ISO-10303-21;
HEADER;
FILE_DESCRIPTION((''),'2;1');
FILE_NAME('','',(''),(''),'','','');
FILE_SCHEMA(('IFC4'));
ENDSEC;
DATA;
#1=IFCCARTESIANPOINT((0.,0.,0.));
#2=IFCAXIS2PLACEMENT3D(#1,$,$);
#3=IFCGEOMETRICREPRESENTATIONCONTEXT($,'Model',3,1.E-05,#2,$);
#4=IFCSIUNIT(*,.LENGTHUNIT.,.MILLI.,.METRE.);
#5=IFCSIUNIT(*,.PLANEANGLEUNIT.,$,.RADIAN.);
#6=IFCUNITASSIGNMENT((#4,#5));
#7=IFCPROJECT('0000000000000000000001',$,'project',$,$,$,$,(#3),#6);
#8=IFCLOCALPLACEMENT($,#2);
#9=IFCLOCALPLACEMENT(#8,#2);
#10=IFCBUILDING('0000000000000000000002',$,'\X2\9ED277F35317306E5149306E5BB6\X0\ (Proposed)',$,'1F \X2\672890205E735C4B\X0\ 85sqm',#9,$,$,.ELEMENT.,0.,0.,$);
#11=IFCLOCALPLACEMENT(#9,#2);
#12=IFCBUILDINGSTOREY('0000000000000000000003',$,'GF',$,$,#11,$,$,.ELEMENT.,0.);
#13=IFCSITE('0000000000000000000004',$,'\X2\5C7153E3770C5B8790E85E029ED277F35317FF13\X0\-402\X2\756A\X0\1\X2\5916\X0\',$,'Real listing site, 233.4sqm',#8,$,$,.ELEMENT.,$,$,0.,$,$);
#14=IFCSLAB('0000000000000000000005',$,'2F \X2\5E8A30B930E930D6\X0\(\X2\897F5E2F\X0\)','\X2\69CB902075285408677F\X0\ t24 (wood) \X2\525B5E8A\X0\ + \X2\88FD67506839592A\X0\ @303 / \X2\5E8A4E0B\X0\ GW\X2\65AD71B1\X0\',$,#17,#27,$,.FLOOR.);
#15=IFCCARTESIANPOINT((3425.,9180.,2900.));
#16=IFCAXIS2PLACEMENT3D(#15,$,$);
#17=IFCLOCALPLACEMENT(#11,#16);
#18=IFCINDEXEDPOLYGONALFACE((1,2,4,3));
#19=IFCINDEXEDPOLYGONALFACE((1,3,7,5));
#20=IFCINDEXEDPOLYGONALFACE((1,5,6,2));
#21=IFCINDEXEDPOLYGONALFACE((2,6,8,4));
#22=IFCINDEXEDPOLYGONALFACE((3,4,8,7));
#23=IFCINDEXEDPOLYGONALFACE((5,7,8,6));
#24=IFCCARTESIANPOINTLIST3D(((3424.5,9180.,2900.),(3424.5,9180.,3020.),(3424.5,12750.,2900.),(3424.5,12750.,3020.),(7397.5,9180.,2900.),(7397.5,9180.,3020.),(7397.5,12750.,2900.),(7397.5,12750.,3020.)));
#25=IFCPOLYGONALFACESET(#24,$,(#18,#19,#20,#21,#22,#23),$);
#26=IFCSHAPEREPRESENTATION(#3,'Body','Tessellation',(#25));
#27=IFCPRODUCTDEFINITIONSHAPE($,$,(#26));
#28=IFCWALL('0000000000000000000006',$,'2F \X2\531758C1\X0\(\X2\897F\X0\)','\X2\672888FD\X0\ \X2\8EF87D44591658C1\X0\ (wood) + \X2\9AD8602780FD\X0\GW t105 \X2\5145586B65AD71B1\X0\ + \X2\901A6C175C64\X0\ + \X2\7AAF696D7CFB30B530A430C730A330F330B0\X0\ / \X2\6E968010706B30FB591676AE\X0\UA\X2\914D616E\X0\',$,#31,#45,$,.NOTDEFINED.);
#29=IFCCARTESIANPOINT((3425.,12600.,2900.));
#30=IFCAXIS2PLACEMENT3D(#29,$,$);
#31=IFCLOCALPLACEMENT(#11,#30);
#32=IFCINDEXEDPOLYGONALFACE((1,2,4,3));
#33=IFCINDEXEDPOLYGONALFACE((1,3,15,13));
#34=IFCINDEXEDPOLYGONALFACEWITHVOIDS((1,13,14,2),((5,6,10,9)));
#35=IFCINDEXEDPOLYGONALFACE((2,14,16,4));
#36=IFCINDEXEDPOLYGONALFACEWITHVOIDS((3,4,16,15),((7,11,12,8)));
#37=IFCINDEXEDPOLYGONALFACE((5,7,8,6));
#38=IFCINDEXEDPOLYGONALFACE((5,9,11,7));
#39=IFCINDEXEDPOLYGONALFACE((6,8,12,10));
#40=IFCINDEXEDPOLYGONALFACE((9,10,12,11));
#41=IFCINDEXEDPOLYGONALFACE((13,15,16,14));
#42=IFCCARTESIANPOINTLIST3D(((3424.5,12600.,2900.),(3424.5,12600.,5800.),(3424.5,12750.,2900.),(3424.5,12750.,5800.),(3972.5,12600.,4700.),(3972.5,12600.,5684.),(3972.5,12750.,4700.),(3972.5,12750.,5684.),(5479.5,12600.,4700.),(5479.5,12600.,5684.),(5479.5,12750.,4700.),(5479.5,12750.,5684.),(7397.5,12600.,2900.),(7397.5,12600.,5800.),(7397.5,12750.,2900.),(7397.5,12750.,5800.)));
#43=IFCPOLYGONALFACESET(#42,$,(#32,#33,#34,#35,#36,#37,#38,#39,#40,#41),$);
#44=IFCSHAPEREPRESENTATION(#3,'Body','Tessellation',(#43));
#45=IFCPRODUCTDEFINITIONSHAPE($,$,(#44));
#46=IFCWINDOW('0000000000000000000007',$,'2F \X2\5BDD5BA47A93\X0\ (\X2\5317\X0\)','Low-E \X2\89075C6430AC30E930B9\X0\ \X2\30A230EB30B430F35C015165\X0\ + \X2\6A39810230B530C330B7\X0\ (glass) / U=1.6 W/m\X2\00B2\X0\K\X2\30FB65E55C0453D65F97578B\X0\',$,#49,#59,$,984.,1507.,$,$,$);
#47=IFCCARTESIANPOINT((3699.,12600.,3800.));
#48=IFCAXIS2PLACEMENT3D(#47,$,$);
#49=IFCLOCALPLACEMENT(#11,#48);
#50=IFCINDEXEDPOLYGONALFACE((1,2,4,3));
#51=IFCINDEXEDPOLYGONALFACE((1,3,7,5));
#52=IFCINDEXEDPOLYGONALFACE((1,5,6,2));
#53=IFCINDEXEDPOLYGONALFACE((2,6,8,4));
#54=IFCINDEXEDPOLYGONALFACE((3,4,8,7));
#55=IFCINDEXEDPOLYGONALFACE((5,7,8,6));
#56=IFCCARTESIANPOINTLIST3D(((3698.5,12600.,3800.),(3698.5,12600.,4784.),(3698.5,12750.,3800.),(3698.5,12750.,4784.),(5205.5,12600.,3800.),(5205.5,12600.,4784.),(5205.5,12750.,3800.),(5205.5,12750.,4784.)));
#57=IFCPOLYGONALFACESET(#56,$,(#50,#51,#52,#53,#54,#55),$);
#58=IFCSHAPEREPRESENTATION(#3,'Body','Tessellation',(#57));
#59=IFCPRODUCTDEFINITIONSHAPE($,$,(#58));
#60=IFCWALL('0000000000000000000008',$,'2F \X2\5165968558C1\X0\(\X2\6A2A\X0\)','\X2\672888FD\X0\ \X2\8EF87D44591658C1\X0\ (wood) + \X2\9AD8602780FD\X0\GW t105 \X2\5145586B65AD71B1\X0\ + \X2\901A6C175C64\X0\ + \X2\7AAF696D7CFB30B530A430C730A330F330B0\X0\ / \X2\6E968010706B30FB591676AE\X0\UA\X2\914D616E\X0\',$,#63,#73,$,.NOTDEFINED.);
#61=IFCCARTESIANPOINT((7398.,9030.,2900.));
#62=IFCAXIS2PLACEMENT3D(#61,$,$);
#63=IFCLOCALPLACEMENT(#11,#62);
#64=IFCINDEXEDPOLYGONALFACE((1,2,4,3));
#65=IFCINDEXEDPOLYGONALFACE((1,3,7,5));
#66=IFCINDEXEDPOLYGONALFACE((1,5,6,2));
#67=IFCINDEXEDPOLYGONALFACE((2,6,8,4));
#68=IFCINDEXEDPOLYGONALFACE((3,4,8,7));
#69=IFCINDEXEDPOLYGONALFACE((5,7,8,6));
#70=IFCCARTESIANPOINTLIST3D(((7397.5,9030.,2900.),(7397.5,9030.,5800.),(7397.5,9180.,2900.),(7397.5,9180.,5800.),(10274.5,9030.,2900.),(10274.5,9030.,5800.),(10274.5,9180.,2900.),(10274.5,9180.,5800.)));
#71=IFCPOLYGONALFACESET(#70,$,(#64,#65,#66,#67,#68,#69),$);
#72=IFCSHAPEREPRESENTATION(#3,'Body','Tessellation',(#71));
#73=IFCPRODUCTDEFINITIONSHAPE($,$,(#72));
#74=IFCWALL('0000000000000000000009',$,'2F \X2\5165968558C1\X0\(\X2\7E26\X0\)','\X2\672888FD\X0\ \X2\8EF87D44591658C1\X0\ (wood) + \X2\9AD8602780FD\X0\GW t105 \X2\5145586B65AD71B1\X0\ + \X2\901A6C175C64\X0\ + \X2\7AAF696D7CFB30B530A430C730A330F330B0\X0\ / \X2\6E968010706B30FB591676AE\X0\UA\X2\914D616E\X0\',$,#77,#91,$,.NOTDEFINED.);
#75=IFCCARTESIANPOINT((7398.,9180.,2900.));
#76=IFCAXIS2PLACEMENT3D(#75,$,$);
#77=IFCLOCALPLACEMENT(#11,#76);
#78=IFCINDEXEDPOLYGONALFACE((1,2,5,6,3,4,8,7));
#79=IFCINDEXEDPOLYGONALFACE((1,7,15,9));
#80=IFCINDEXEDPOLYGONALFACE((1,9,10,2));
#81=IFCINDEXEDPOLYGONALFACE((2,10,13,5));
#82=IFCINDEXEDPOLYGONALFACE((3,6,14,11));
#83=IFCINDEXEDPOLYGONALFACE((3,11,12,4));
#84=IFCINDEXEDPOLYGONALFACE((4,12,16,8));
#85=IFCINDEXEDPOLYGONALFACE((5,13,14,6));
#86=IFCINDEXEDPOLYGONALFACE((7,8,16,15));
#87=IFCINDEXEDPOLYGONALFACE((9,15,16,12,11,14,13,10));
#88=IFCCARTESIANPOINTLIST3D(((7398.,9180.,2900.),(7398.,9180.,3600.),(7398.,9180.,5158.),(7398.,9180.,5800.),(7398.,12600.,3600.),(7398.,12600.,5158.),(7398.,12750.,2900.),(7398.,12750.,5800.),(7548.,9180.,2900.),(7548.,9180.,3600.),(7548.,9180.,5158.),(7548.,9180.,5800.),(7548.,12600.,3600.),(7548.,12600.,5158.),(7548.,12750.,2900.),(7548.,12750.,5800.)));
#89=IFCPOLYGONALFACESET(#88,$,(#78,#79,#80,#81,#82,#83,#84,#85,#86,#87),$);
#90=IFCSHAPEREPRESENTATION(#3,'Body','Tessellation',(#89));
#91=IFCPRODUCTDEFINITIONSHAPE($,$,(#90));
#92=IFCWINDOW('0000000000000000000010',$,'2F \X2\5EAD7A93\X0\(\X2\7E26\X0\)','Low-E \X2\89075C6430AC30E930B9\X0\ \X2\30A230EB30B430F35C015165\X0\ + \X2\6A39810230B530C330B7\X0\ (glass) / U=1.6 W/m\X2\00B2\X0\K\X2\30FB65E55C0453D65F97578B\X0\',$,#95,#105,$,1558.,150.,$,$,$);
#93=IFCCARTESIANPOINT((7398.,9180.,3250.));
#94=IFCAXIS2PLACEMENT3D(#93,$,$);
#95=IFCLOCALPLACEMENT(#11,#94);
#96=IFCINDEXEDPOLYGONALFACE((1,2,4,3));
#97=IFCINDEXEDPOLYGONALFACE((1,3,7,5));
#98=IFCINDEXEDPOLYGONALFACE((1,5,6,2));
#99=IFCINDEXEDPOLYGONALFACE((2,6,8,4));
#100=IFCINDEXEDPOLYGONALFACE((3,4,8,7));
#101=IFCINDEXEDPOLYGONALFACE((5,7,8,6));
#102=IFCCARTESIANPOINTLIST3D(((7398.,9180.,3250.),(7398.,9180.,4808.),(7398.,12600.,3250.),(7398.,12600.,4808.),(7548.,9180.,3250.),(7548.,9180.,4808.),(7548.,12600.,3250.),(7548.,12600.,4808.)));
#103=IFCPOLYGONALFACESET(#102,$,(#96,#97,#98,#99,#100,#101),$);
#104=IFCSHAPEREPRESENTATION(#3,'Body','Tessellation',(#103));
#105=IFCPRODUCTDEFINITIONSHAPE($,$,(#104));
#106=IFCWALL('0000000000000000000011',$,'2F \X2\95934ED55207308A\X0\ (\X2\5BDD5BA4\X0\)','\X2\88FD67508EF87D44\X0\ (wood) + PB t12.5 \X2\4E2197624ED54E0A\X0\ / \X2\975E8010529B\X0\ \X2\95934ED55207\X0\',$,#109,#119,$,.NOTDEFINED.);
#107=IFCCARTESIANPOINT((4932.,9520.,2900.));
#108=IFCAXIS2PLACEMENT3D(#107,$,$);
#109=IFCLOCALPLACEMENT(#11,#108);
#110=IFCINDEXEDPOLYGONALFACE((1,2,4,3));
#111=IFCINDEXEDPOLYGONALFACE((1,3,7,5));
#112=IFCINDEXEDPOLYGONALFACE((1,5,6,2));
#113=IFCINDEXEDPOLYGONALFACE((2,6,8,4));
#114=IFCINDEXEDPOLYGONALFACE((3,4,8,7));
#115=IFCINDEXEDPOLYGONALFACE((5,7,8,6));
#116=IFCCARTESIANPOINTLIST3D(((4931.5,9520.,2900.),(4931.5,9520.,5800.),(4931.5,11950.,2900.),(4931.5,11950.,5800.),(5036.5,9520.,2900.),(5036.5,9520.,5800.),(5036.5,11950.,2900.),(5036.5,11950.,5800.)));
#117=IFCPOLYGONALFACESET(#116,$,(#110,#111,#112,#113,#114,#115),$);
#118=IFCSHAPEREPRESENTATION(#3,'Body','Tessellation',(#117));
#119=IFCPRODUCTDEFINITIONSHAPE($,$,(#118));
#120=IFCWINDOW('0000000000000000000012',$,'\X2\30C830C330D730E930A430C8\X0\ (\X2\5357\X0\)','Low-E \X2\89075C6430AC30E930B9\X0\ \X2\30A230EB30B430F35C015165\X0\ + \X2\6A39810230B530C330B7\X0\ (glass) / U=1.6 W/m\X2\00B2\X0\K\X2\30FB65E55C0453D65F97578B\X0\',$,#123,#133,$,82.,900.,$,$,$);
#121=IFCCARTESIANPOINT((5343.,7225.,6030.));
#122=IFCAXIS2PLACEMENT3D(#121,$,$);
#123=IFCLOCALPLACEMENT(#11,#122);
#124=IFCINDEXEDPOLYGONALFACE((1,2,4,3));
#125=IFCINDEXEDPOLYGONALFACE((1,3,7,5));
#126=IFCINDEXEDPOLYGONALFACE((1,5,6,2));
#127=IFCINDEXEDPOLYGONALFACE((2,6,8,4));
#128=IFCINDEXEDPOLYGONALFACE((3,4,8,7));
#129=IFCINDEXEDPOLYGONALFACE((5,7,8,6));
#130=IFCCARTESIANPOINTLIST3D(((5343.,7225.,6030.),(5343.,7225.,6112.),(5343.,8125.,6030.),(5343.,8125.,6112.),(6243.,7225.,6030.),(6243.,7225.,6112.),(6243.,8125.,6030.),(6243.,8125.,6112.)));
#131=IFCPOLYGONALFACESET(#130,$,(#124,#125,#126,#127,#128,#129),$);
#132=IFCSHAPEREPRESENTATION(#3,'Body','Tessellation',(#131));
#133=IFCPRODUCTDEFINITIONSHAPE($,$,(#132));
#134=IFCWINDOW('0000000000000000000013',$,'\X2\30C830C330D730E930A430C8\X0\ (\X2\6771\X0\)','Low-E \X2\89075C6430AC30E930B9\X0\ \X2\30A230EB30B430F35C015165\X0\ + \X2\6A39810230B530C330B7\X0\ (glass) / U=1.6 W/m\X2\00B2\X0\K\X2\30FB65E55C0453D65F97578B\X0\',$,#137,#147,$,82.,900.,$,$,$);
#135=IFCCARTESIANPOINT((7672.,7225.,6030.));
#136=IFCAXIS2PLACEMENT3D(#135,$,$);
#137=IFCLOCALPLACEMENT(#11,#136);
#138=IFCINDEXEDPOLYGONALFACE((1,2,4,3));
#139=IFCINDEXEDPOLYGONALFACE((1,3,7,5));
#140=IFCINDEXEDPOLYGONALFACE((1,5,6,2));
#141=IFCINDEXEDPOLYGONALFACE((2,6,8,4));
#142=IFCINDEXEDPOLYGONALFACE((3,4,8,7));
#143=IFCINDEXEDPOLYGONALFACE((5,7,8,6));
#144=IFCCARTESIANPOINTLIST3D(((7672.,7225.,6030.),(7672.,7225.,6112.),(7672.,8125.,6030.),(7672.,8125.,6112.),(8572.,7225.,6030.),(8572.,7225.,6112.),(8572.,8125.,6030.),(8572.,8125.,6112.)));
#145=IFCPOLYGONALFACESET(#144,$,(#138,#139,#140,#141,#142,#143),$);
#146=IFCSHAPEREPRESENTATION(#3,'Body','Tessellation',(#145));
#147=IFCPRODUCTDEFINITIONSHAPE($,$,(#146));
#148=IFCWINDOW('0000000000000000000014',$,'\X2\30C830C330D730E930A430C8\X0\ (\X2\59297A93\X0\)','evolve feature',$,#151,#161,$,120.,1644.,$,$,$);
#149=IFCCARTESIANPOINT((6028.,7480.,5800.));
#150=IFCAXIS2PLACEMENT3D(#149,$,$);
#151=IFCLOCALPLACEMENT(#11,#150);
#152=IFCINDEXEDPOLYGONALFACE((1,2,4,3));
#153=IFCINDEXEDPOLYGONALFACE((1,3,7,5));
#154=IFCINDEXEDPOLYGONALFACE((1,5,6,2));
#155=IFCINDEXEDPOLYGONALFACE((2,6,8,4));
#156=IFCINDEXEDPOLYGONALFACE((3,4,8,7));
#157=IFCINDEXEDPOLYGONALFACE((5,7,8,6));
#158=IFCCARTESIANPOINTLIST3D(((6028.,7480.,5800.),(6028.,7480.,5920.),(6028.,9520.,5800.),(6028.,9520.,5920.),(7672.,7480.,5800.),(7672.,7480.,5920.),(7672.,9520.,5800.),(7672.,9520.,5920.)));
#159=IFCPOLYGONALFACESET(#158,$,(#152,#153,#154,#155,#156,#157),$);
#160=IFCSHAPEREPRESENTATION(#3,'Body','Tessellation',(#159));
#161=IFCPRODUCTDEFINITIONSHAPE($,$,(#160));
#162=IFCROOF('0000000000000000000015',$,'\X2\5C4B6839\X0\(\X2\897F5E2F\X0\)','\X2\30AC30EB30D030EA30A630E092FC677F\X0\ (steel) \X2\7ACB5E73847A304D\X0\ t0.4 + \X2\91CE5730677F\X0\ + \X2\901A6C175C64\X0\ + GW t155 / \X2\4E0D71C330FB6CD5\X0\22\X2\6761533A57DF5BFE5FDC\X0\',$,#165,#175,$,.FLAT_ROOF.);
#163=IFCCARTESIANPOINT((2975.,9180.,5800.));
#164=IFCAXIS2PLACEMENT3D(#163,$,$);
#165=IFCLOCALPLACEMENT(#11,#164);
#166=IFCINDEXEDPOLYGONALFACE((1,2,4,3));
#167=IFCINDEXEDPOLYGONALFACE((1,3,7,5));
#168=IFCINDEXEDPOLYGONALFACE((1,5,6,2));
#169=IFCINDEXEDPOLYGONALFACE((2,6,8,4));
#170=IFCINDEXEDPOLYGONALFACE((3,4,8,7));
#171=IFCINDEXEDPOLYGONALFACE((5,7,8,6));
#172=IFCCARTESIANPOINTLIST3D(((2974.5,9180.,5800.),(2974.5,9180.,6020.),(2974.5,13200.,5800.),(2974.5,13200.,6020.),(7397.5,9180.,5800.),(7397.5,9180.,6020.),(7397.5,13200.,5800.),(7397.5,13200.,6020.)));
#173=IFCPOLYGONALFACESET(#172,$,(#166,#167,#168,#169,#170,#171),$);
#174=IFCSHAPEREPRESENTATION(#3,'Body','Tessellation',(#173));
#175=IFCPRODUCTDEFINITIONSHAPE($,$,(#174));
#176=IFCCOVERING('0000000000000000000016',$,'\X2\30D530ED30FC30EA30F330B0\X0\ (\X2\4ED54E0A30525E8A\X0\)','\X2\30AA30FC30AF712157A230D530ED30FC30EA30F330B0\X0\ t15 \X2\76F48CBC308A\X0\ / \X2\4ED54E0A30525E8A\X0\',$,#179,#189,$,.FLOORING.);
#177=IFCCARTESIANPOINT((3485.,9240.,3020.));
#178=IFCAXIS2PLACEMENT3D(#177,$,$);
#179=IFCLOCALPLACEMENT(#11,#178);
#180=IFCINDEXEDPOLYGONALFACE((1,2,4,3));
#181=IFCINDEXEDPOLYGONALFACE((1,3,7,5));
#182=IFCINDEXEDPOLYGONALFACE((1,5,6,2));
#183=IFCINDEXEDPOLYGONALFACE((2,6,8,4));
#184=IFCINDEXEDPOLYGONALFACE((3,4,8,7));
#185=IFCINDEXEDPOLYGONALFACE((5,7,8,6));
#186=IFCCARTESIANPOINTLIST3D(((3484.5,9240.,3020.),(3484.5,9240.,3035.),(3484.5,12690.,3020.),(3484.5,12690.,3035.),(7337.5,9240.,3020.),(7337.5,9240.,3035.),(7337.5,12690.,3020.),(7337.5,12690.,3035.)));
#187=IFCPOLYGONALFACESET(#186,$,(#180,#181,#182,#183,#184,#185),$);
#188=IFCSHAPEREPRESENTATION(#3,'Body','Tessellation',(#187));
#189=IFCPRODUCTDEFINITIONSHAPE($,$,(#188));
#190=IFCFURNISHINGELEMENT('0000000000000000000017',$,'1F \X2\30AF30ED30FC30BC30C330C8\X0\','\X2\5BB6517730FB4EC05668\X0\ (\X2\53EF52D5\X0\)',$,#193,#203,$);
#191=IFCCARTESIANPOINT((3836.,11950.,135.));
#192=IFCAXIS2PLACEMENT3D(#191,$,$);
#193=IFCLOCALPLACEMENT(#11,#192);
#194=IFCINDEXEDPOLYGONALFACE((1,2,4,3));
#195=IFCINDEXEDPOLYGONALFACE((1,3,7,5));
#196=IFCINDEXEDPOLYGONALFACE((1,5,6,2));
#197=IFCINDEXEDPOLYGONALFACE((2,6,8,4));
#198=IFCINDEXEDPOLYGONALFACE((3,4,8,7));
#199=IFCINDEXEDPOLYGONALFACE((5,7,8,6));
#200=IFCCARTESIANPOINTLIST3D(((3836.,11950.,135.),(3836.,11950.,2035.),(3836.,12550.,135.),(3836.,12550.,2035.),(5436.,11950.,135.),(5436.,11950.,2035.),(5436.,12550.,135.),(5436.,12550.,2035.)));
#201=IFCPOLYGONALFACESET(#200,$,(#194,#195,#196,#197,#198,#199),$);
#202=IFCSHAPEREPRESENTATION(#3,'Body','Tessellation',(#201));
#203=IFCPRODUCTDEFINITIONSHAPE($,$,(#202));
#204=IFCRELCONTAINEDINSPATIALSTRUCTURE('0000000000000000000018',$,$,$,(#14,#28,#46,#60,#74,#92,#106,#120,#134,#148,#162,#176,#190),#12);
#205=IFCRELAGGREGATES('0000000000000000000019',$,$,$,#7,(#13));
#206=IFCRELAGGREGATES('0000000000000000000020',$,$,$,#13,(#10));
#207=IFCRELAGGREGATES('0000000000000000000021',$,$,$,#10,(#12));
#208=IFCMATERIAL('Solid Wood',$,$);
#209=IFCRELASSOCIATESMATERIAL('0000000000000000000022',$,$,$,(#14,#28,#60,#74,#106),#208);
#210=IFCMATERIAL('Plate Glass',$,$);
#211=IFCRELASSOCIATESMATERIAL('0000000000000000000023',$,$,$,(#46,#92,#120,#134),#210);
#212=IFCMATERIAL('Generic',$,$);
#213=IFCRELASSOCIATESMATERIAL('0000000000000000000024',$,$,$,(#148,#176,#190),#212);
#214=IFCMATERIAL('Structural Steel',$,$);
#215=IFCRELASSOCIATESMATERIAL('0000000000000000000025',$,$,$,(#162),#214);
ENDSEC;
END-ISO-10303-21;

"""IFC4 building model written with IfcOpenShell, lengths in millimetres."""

from ifc_helpers import new_model, si_unit, frame, frame_2d, origin, place, context, project, spatial, rectangle, extrude, material, element, fill, save


model = new_model("IFC4")

# Units and contexts
model_context = context("Model", 3, precision=1e-05, world=origin())
ifc_project = project(units=[si_unit("LENGTHUNIT", "METRE", prefix="MILLI"), si_unit("PLANEANGLEUNIT", "RADIAN")], contexts=[model_context])

# Site, building, storey
site_placement = place(None, origin())
site = spatial("IfcSite", under=ifc_project, at=site_placement, Name="山口県宇部市黒石北３-402番1外", ObjectType="Real listing site, 233.4sqm", CompositionType="ELEMENT", RefElevation=0.0)
building_placement = place(site_placement, origin())
building = spatial("IfcBuilding", under=site, at=building_placement, Name="黒石北の光の家 (Proposed)", ObjectType="1F 木造平屋 85sqm", CompositionType="ELEMENT", ElevationOfRefHeight=0.0, ElevationOfTerrain=0.0)
storey_placement = place(building_placement, origin())
storey = spatial("IfcBuildingStorey", under=building, at=storey_placement, Name="GF", CompositionType="ELEMENT", Elevation=0.0)

# Slab
ifc_material_1 = material(Name="Solid Wood")
slab_placement = place(storey_placement, frame((3425.0, 9180.0, 2900.0)))
element("IfcSlab", 1, at=slab_placement, inside=storey, material=ifc_material_1, Name="2F 床スラブ(西帯)", Description="構造用合板 t24 (wood) 剛床 + 製材根太 @303 / 床下 GW断熱", PredefinedType="FLOOR", context=model_context, shape_type="SweptSolid", body=[
    extrude(rectangle(XDim=3973.0, YDim=3570.0, at=frame_2d((1986.0, 1785.0))), frame((3425.0, 9180.0, 2900.0)), (0.0, 0.0, 1.0), 120.0),
])

# Wall, opening, window
wall_1_placement = place(storey_placement, frame((3425.0, 12600.0, 2900.0)))
wall_1 = element("IfcWall", 2, at=wall_1_placement, inside=storey, material=ifc_material_1, Name="2F 北壁(西)", Description="木製 軸組外壁 (wood) + 高性能GW t105 充填断熱 + 通気層 + 窯業系サイディング / 準耐火・外皮UA配慮", PredefinedType="NOTDEFINED", context=model_context, shape_type="SweptSolid", body=[
    extrude(rectangle(XDim=3973.0, YDim=150.0, at=frame_2d((1986.0, 75.0))), frame((3425.0, 12600.0, 2900.0)), (0.0, 0.0, 1.0), 2900.0),
])
opening_1_placement = place(storey_placement, frame((3699.0, 12600.0, 3800.0)))
opening_1 = element("IfcOpeningElement", 3, at=opening_1_placement, cuts=wall_1, PredefinedType="NOTDEFINED", context=model_context, shape_type="SweptSolid", body=[
    extrude(rectangle(XDim=1507.0, YDim=150.0, at=frame_2d((753.0, 75.0))), frame((3699.0, 12600.0, 3800.0)), (0.0, 0.0, 1.0), 984.0),
])
ifc_material_2 = material(Name="Plate Glass")
window_1_placement = place(storey_placement, frame((3699.0, 12600.0, 3800.0)))
window_1 = element("IfcWindow", 4, at=window_1_placement, inside=storey, material=ifc_material_2, Name="2F 寝室窓 (北)", Description="Low-E 複層ガラス アルゴン封入 + 樹脂サッシ (glass) / U=1.6 W/m²K・日射取得型", OverallHeight=984.0, OverallWidth=1507.0, context=model_context, shape_type="SweptSolid", body=[
    extrude(rectangle(XDim=1507.0, YDim=150.0, at=frame_2d((753.0, 75.0))), frame((3699.0, 12600.0, 3800.0)), (0.0, 0.0, 1.0), 984.0),
])
fill(opening_1, window_1)

# Wall
wall_2_placement = place(storey_placement, frame((7398.0, 9030.0, 2900.0)))
element("IfcWall", 5, at=wall_2_placement, inside=storey, material=ifc_material_1, Name="2F 入隅壁(横)", Description="木製 軸組外壁 (wood) + 高性能GW t105 充填断熱 + 通気層 + 窯業系サイディング / 準耐火・外皮UA配慮", PredefinedType="NOTDEFINED", context=model_context, shape_type="SweptSolid", body=[
    extrude(rectangle(XDim=2877.0, YDim=150.0, at=frame_2d((1438.0, 75.0))), frame((7398.0, 9030.0, 2900.0)), (0.0, 0.0, 1.0), 2900.0),
])

# Wall, opening, window
wall_3_placement = place(storey_placement, frame((7398.0, 9180.0, 2900.0)))
wall_3 = element("IfcWall", 6, at=wall_3_placement, inside=storey, material=ifc_material_1, Name="2F 入隅壁(縦)", Description="木製 軸組外壁 (wood) + 高性能GW t105 充填断熱 + 通気層 + 窯業系サイディング / 準耐火・外皮UA配慮", PredefinedType="NOTDEFINED", context=model_context, shape_type="SweptSolid", body=[
    extrude(rectangle(XDim=150.0, YDim=3570.0, at=frame_2d((75.0, 1785.0))), frame((7398.0, 9180.0, 2900.0)), (0.0, 0.0, 1.0), 2900.0),
])
opening_2_placement = place(storey_placement, frame((7398.0, 9180.0, 3250.0)))
opening_2 = element("IfcOpeningElement", 7, at=opening_2_placement, cuts=wall_3, PredefinedType="NOTDEFINED", context=model_context, shape_type="SweptSolid", body=[
    extrude(rectangle(XDim=150.0, YDim=3420.0, at=frame_2d((75.0, 1710.0))), frame((7398.0, 9180.0, 3250.0)), (0.0, 0.0, 1.0), 1558.0),
])
window_2_placement = place(storey_placement, frame((7398.0, 9180.0, 3250.0)))
window_2 = element("IfcWindow", 8, at=window_2_placement, inside=storey, material=ifc_material_2, Name="2F 庭窓(縦)", Description="Low-E 複層ガラス アルゴン封入 + 樹脂サッシ (glass) / U=1.6 W/m²K・日射取得型", OverallHeight=1558.0, OverallWidth=150.0, context=model_context, shape_type="SweptSolid", body=[
    extrude(rectangle(XDim=150.0, YDim=3420.0, at=frame_2d((75.0, 1710.0))), frame((7398.0, 9180.0, 3250.0)), (0.0, 0.0, 1.0), 1558.0),
])
fill(opening_2, window_2)

# Wall
wall_4_placement = place(storey_placement, frame((4932.0, 9520.0, 2900.0)))
element("IfcWall", 9, at=wall_4_placement, inside=storey, material=ifc_material_1, Name="2F 間仕切り (寝室)", Description="製材軸組 (wood) + PB t12.5 両面仕上 / 非耐力 間仕切", PredefinedType="NOTDEFINED", context=model_context, shape_type="SweptSolid", body=[
    extrude(rectangle(XDim=105.0, YDim=2430.0, at=frame_2d((52.0, 1215.0))), frame((4932.0, 9520.0, 2900.0)), (0.0, 0.0, 1.0), 2900.0),
])

# Windows
window_3_placement = place(storey_placement, frame((5343.0, 7225.0, 6030.0)))
element("IfcWindow", 10, at=window_3_placement, inside=storey, material=ifc_material_2, Name="トップライト (南)", Description="Low-E 複層ガラス アルゴン封入 + 樹脂サッシ (glass) / U=1.6 W/m²K・日射取得型", OverallHeight=82.0, OverallWidth=900.0, context=model_context, shape_type="SweptSolid", body=[
    extrude(rectangle(XDim=900.0, YDim=900.0, at=frame_2d((450.0, 450.0))), frame((5343.0, 7225.0, 6030.0)), (0.0, 0.0, 1.0), 82.0),
])
window_4_placement = place(storey_placement, frame((7672.0, 7225.0, 6030.0)))
element("IfcWindow", 11, at=window_4_placement, inside=storey, material=ifc_material_2, Name="トップライト (東)", Description="Low-E 複層ガラス アルゴン封入 + 樹脂サッシ (glass) / U=1.6 W/m²K・日射取得型", OverallHeight=82.0, OverallWidth=900.0, context=model_context, shape_type="SweptSolid", body=[
    extrude(rectangle(XDim=900.0, YDim=900.0, at=frame_2d((450.0, 450.0))), frame((7672.0, 7225.0, 6030.0)), (0.0, 0.0, 1.0), 82.0),
])
ifc_material_3 = material(Name="Generic")
window_5_placement = place(storey_placement, frame((6028.0, 7480.0, 5800.0)))
element("IfcWindow", 12, at=window_5_placement, inside=storey, material=ifc_material_3, Name="トップライト (天窓)", Description="evolve feature", OverallHeight=120.0, OverallWidth=1644.0, context=model_context, shape_type="SweptSolid", body=[
    extrude(rectangle(XDim=1644.0, YDim=2040.0, at=frame_2d((822.0, 1020.0))), frame((6028.0, 7480.0, 5800.0)), (0.0, 0.0, 1.0), 120.0),
])

# Roof
ifc_material_4 = material(Name="Structural Steel")
for number, where, name in (
    (13, (2975.0, 9180.0, 5800.0), "屋根(西帯)"),
):
    element("IfcRoof", number, at=place(storey_placement, frame(where)), inside=storey, material=ifc_material_4, Name=name, Description="ガルバリウム鋼板 (steel) 立平葺き t0.4 + 野地板 + 通気層 + GW t155 / 不燃・法22条区域対応", PredefinedType="FLAT_ROOF", context=model_context, shape_type="SweptSolid", body=[
        extrude(rectangle(XDim=4423.0, YDim=4020.0, at=frame_2d((2211.0, 2010.0))), frame((2975.0, 9180.0, 5800.0)), (0.0, 0.0, 1.0), 220.0),
    ])

# Covering
covering_placement = place(storey_placement, frame((3485.0, 9240.0, 3020.0)))
element("IfcCovering", 14, at=covering_placement, inside=storey, material=ifc_material_3, Name="フローリング (仕上げ床)", Description="オーク無垢フローリング t15 直貼り / 仕上げ床", PredefinedType="FLOORING", context=model_context, shape_type="SweptSolid", body=[
    extrude(rectangle(XDim=3853.0, YDim=3450.0, at=frame_2d((1926.0, 1725.0))), frame((3485.0, 9240.0, 3020.0)), (0.0, 0.0, 1.0), 15.0),
])

# Furnishing element
furnishing_1_placement = place(storey_placement, frame((3836.0, 11950.0, 135.0)))
element("IfcFurnishingElement", 15, at=furnishing_1_placement, inside=storey, material=ifc_material_3, Name="1F クローゼット", Description="家具・什器 (可動)", context=model_context, shape_type="SweptSolid", body=[
    extrude(rectangle(XDim=1600.0, YDim=600.0, at=frame_2d((800.0, 300.0))), frame((3836.0, 11950.0, 135.0)), (0.0, 0.0, 1.0), 1900.0),
])

save(model, "model.ifc")
